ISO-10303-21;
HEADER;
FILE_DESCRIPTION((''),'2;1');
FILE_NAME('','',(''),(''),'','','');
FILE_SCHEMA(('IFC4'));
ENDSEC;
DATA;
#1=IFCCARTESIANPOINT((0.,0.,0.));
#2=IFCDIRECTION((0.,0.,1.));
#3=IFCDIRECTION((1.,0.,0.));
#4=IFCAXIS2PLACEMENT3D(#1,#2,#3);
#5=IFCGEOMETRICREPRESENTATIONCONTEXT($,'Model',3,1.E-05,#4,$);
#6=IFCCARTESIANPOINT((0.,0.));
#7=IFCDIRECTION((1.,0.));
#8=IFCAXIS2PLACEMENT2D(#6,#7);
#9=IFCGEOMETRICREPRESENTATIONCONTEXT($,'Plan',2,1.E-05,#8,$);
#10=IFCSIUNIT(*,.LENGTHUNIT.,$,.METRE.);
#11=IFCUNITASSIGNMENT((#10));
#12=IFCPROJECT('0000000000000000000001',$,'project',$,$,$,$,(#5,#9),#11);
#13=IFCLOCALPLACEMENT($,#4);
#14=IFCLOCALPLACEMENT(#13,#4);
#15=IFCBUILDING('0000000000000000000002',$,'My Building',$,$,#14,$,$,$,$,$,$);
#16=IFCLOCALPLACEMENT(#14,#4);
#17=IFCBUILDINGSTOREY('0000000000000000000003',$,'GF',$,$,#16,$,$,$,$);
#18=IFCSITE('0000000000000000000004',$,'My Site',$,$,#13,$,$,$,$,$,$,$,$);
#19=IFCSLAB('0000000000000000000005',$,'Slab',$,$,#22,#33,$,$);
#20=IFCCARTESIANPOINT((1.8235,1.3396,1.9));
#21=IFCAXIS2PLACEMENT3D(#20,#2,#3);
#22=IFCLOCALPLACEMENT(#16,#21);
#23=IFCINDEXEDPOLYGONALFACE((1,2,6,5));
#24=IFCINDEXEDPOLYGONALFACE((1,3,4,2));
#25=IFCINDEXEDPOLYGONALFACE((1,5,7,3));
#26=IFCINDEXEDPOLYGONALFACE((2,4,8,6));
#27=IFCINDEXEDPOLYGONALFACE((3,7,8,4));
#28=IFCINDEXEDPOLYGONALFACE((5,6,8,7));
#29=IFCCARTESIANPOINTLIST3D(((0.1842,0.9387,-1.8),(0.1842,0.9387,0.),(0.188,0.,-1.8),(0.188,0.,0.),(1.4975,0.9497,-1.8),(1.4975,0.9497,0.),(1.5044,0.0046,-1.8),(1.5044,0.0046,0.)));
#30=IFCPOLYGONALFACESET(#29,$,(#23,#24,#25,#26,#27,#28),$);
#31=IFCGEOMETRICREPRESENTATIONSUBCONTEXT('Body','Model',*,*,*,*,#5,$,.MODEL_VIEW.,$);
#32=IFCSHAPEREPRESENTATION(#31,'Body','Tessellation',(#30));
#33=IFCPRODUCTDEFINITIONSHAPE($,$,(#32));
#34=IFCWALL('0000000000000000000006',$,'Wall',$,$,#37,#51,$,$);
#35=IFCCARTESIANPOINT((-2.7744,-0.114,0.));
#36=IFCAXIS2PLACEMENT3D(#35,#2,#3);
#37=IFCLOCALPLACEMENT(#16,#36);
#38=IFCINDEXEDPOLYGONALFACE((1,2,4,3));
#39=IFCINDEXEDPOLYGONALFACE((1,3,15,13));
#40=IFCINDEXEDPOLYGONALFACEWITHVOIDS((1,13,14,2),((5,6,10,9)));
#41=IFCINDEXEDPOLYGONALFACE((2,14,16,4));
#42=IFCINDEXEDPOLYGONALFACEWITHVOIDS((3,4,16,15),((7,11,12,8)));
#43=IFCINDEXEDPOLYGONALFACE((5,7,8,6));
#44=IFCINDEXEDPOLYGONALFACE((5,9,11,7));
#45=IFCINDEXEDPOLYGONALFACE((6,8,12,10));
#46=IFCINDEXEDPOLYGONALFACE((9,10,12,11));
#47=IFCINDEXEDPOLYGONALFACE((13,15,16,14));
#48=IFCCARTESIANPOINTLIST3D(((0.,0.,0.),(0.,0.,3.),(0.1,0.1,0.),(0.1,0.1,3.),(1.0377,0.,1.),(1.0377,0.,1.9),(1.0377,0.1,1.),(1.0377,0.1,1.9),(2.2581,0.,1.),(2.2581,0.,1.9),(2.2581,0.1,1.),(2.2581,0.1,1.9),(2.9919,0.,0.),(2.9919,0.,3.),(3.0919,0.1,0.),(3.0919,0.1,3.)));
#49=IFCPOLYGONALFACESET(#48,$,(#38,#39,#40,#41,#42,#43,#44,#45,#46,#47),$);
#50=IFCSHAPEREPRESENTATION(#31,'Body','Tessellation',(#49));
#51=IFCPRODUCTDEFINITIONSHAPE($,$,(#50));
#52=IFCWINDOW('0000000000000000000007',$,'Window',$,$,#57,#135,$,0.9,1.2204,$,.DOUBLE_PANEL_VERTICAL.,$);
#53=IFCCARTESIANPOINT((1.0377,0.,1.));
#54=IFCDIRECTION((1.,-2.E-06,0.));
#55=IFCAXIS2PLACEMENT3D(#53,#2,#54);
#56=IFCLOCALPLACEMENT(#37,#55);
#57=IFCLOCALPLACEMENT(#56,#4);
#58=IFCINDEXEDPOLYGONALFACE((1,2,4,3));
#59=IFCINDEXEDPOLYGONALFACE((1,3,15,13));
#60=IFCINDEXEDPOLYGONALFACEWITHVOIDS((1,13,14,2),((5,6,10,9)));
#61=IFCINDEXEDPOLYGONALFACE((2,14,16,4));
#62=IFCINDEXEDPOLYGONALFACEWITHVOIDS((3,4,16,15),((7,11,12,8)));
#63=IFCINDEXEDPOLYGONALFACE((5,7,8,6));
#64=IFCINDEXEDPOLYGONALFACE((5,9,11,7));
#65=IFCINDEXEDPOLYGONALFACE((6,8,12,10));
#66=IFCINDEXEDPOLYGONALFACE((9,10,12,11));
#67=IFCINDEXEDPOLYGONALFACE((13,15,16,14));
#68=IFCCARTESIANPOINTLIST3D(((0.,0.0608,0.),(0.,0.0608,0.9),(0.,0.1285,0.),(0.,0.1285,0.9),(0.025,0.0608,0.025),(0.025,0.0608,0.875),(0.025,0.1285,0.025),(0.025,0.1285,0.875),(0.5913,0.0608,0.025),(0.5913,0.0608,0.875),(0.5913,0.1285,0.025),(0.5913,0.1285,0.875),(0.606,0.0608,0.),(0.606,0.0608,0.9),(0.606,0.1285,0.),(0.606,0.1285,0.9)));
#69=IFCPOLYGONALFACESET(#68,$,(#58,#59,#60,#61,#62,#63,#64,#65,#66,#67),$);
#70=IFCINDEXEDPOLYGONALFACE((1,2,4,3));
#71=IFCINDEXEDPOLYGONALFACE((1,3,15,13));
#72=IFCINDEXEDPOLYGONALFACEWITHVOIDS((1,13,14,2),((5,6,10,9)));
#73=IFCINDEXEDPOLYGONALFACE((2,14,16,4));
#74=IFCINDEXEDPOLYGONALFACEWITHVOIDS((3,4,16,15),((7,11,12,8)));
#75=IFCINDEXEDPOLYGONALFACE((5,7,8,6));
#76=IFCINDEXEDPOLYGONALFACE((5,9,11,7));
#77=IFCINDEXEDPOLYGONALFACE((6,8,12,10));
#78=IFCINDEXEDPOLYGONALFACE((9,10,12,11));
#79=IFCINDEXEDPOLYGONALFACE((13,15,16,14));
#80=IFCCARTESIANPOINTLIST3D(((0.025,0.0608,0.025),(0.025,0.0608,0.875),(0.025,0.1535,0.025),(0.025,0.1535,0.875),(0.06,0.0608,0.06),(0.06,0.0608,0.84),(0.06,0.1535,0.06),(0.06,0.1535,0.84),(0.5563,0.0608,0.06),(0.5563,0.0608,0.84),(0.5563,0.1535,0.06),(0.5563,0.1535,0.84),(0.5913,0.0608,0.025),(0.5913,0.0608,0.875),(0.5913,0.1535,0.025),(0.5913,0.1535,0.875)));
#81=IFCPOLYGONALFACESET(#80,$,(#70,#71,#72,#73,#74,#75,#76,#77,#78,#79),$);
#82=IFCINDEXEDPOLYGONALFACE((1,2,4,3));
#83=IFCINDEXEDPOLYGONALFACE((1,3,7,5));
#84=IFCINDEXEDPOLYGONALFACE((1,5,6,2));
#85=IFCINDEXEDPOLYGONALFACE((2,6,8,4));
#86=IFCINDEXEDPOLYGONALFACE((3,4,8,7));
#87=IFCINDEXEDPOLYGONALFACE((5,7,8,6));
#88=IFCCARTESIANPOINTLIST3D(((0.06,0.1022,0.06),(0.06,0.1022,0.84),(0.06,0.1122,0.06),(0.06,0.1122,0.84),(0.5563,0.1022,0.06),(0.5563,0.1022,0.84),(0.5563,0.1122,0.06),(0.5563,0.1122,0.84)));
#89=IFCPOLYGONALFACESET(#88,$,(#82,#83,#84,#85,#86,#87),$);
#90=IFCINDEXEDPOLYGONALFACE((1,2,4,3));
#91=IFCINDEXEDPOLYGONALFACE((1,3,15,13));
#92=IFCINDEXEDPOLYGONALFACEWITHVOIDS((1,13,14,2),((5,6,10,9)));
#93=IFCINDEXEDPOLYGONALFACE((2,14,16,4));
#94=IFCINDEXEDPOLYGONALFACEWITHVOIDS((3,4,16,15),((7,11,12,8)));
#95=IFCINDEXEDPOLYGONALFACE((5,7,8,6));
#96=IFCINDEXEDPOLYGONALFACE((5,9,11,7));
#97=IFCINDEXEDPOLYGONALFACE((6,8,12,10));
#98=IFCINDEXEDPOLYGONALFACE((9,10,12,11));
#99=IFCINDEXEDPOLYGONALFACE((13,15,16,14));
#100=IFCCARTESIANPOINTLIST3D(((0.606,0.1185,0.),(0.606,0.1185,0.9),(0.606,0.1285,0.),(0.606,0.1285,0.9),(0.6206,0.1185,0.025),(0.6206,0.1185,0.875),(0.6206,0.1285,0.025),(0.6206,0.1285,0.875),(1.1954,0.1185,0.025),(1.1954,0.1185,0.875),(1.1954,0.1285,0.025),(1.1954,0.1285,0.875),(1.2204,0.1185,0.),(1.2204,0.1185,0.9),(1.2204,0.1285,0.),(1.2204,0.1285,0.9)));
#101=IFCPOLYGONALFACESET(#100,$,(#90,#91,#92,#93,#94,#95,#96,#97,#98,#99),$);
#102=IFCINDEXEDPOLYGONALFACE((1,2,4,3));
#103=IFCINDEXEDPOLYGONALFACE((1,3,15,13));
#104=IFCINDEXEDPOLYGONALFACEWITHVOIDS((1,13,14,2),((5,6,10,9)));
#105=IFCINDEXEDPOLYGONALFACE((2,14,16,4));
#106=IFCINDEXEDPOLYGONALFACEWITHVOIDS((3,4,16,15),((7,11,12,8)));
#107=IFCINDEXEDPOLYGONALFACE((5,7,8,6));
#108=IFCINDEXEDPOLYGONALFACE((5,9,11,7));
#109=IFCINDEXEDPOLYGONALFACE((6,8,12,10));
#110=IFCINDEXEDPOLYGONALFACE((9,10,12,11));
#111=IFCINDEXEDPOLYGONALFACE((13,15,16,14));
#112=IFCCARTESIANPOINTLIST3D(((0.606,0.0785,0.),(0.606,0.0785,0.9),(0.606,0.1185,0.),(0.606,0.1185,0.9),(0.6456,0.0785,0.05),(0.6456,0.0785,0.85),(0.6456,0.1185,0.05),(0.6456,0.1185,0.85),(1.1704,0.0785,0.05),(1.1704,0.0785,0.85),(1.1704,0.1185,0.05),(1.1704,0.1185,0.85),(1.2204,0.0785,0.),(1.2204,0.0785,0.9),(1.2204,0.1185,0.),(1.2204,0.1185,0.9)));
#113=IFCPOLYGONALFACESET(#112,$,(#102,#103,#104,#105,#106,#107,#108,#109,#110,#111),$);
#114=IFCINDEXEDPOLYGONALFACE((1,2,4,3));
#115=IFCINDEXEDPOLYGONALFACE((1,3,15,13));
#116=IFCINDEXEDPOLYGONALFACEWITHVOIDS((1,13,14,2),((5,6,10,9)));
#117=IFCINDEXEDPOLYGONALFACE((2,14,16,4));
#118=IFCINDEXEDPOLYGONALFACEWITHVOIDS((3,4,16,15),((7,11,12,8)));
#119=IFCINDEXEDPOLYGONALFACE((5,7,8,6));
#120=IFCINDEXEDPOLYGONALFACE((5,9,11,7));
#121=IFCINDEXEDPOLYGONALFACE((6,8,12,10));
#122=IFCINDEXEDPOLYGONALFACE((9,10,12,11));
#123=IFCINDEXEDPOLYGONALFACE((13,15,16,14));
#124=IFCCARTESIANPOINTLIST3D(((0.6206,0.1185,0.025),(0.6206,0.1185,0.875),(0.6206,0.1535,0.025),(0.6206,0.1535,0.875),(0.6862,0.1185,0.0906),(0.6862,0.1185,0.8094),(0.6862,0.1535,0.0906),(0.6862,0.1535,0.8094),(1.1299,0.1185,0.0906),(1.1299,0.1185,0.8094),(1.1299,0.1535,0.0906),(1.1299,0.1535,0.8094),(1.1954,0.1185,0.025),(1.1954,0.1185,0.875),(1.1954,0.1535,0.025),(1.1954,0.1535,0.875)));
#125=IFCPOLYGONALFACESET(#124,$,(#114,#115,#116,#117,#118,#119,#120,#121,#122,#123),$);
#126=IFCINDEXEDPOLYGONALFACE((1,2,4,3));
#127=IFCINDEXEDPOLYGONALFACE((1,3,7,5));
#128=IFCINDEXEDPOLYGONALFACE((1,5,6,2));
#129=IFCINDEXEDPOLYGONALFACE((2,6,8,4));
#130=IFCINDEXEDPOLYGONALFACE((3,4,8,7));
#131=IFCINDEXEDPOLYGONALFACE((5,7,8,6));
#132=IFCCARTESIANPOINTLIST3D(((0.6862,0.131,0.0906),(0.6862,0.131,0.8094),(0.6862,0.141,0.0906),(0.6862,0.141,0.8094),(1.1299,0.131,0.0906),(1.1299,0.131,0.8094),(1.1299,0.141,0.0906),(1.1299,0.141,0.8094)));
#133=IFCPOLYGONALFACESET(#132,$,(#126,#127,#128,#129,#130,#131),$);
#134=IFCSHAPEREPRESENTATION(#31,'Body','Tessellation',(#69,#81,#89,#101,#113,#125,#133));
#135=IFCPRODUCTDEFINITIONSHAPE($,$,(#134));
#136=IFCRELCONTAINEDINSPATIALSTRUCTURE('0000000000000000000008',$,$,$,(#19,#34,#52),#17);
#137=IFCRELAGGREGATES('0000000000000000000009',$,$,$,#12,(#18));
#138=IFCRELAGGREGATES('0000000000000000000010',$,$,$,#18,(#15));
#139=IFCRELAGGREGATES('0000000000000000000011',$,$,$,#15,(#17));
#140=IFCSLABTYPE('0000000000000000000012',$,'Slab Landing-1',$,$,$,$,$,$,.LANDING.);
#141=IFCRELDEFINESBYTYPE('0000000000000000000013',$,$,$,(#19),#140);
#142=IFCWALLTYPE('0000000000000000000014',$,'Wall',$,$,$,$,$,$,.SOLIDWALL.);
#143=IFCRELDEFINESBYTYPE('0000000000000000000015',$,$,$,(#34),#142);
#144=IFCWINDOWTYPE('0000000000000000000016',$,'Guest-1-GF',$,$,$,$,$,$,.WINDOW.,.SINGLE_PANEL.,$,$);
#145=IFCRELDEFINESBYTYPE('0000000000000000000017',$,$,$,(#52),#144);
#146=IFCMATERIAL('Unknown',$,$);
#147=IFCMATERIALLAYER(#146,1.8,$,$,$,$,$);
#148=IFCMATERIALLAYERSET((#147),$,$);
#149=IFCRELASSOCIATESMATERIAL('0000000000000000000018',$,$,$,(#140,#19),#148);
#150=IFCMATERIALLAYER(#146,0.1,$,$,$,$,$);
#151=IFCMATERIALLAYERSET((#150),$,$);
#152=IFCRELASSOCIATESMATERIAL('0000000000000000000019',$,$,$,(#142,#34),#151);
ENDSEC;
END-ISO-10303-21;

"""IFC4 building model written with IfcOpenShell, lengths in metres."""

from ifc_helpers import new_model, entity, si_unit, frame, origin_with_axes, origin_2d_with_axis, place, context, subcontext, project, spatial, line, indexed_curve, outline, extrude, shape, source, transform, mapped, material, layer, layer_set, layer_usage, type_object, type_shapes, element, fill, save


model = new_model("IFC4")

# Units and contexts
model_context = context("Model", 3, precision=1e-05, world=origin_with_axes())
plan_context = context("Plan", 2, precision=1e-05, world=origin_2d_with_axis())
body_context_1 = subcontext(model_context, "Body", "Model", "MODEL_VIEW")
body_context_2 = subcontext(plan_context, "Body", "Plan", "PLAN_VIEW")
ifc_project = project(units=[si_unit("LENGTHUNIT", "METRE")], contexts=[model_context, plan_context])

# Site, building, storey
site_placement = place(None, origin_with_axes())
site = spatial("IfcSite", under=ifc_project, at=site_placement, Name="My Site")
building_placement = place(site_placement, origin_with_axes())
building = spatial("IfcBuilding", under=site, at=building_placement, Name="My Building")
storey_placement = place(building_placement, origin_with_axes())
storey = spatial("IfcBuildingStorey", under=building, at=storey_placement, Name="GF")

# Shared definitions
ifc_material = material(Name="Unknown")

# Slab
ifc_layer_1 = layer(ifc_material, 1.8)
ifc_layer_set_1 = layer_set([ifc_layer_1])
ifc_layer_usage_1 = layer_usage(ifc_layer_set_1, "AXIS3", "POSITIVE", -1.8)
slab_type_1 = type_object("IfcSlabType", Name="Slab Landing-1", PredefinedType="LANDING", material=ifc_layer_set_1)
slab_1_placement = place(storey_placement, frame((1.8235, 1.3396, 1.9), z_axis=(0.0, 0.0, 1.0), x_axis=(1.0, 0.0, 0.0)))
element("IfcSlab", 1, at=slab_1_placement, inside=storey, type_object=slab_type_1, material=ifc_layer_usage_1, Name="Slab", context=body_context_1, shape_type="SweptSolid", body=[
    extrude(outline(indexed_curve([(0.1842, 0.9387), (1.4975, 0.9497), (1.5044, 0.0046), (0.188, 0.0), (0.1842, 0.9387)])), frame((0.0, 0.0, -1.8), z_axis=(0.0, 0.0, 1.0), x_axis=(1.0, 0.0, 0.0)), (0.0, 0.0, 1.0), 1.8),
])

# Shared definitions
ifc_layer_2 = layer(ifc_material, 0.1)
ifc_layer_set_2 = layer_set([ifc_layer_2])
wall_type = type_object("IfcWallType", Name="Wall", PredefinedType="SOLIDWALL", material=ifc_layer_set_2)

# Wall, opening, window
ifc_layer_usage_2 = layer_usage(ifc_layer_set_2, "AXIS2", "POSITIVE", 0.0)
wall_1_placement = place(storey_placement, frame((-2.7744, -0.114, 0.0), z_axis=(0.0, 0.0, 1.0), x_axis=(1.0, 0.0, 0.0)))
wall_1 = element("IfcWall", 2, at=wall_1_placement, inside=storey, type_object=wall_type, material=ifc_layer_usage_2, Name="Wall", context=body_context_1, shape_type="SweptSolid", body=[
    extrude(outline(indexed_curve([(0.0, 0.0), (0.1, 0.1), (3.0919, 0.1), (2.9919, 0.0)], segments=[line(1, 2, 3, 4, 1)])), origin_with_axes(), (0.0, 0.0, 1.0), 3.0),
])
shared_shape_1 = source(origin_with_axes(), body_context_1, "Body", "SweptSolid", [
    extrude(outline(indexed_curve([(0.0, 0.0), (1.2204, 0.0), (1.2204, 0.9), (0.0, 0.9)], segments=[line(1, 2, 3, 4, 1)])), frame((0.0, -0.6, 0.0), z_axis=(0.0, -1.0, 0.0), x_axis=(1.0, 0.0, 0.0)), (0.0, 0.0, -1.0), 1.2),
])
opening_1_placement = place(wall_1_placement, frame((1.0377, 0.0, 1.0), z_axis=(0.0, 0.0, 1.0), x_axis=(1.0, -0.000002, 0.0)))
opening_1 = element("IfcOpeningElement", 3, at=opening_1_placement, cuts=wall_1, PredefinedType="OPENING", context=body_context_1, shape_type="MappedRepresentation", body=[
    mapped(shared_shape_1, transform((0.0, 0.0, 0.0), x_axis=(1.0, 0.0, 0.0), y_axis=(0.0, 1.0, 0.0), z_axis=(0.0, 0.0, 1.0), scale=1.0)),
])
window_type_1 = type_object("IfcWindowType", Name="Guest-1-GF", PartitioningType="SINGLE_PANEL", PredefinedType="WINDOW")
shared_shape_2 = source(origin_with_axes(), body_context_1, "Body", "SweptSolid", [
    extrude(outline(indexed_curve([(0.0, 0.0), (0.606, 0.0), (0.606, 0.9), (0.0, 0.9)], segments=[line(1, 2, 3, 4, 1)]), holes=[indexed_curve([(0.025, 0.025), (0.5913, 0.025), (0.5913, 0.875), (0.025, 0.875)], segments=[line(1, 2, 3, 4, 1)])]), frame((0.0, 0.0608, 0.0), z_axis=(0.0, -1.0, 0.0), x_axis=(1.0, 0.0, 0.0)), (0.0, 0.0, -1.0), 0.0677),
    extrude(outline(indexed_curve([(0.0, 0.0), (0.606, 0.0), (0.606, 0.9), (0.0, 0.9)], segments=[line(1, 2, 3, 4, 1)]), holes=[indexed_curve([(0.05, 0.05), (0.5663, 0.05), (0.5663, 0.85), (0.05, 0.85)], segments=[line(1, 2, 3, 4, 1)])]), frame((0.0, 0.0785, 0.0), z_axis=(0.0, -1.0, 0.0), x_axis=(1.0, 0.0, 0.0)), (0.0, 0.0, -1.0), -0.0177),
    extrude(outline(indexed_curve([(0.0, 0.0), (0.5663, 0.0), (0.5663, 0.85), (0.0, 0.85)], segments=[line(1, 2, 3, 4, 1)]), holes=[indexed_curve([(0.035, 0.035), (0.5313, 0.035), (0.5313, 0.815), (0.035, 0.815)], segments=[line(1, 2, 3, 4, 1)])]), frame((0.025, 0.0608, 0.025), z_axis=(0.0, -1.0, 0.0), x_axis=(1.0, 0.0, 0.0)), (0.0, 0.0, -1.0), 0.0927),
    extrude(outline(indexed_curve([(0.035, 0.035), (0.5313, 0.035), (0.5313, 0.815), (0.035, 0.815)], segments=[line(1, 2, 3, 4, 1)])), frame((0.025, 0.1022, 0.025), z_axis=(0.0, -1.0, 0.0), x_axis=(1.0, 0.0, 0.0)), (0.0, 0.0, -1.0), 0.01),
    extrude(outline(indexed_curve([(0.0, 0.0), (0.6144, 0.0), (0.6144, 0.9), (0.0, 0.9)], segments=[line(1, 2, 3, 4, 1)]), holes=[indexed_curve([(0.0147, 0.025), (0.5894, 0.025), (0.5894, 0.875), (0.0147, 0.875)], segments=[line(1, 2, 3, 4, 1)])]), frame((0.606, 0.1185, 0.0), z_axis=(0.0, -1.0, 0.0), x_axis=(1.0, 0.0, 0.0)), (0.0, 0.0, -1.0), 0.01),
    extrude(outline(indexed_curve([(0.0, 0.0), (0.6144, 0.0), (0.6144, 0.9), (0.0, 0.9)], segments=[line(1, 2, 3, 4, 1)]), holes=[indexed_curve([(0.0397, 0.05), (0.5644, 0.05), (0.5644, 0.85), (0.0397, 0.85)], segments=[line(1, 2, 3, 4, 1)])]), frame((0.606, 0.0785, 0.0), z_axis=(0.0, -1.0, 0.0), x_axis=(1.0, 0.0, 0.0)), (0.0, 0.0, -1.0), 0.04),
    extrude(outline(indexed_curve([(0.0, 0.0), (0.5748, 0.0), (0.5748, 0.85), (0.0, 0.85)], segments=[line(1, 2, 3, 4, 1)]), holes=[indexed_curve([(0.0656, 0.0656), (0.5092, 0.0656), (0.5092, 0.7844), (0.0656, 0.7844)], segments=[line(1, 2, 3, 4, 1)])]), frame((0.6206, 0.1185, 0.025), z_axis=(0.0, -1.0, 0.0), x_axis=(1.0, 0.0, 0.0)), (0.0, 0.0, -1.0), 0.035),
    extrude(outline(indexed_curve([(0.0656, 0.0656), (0.5092, 0.0656), (0.5092, 0.7844), (0.0656, 0.7844)], segments=[line(1, 2, 3, 4, 1)])), frame((0.6206, 0.131, 0.025), z_axis=(0.0, -1.0, 0.0), x_axis=(1.0, 0.0, 0.0)), (0.0, 0.0, -1.0), 0.01),
])
shared_shape_3 = source(origin_with_axes(), body_context_2, "Body", "Curve2D", [
    entity("IfcIndexedPolyCurve", entity("IfcCartesianPointList2D", [[0.05, 0.0785], [0.5663, 0.0785]])),
    entity("IfcIndexedPolyCurve", entity("IfcCartesianPointList2D", [[0.0, 0.1285], [0.025, 0.1285], [0.025, 0.0608], [0.05, 0.0608], [0.05, 0.0785], [0.0, 0.0785]]), [entity("IfcLineIndex", [1, 2, 3, 4, 5, 6, 1])]),
    entity("IfcIndexedPolyCurve", entity("IfcCartesianPointList2D", [[0.606, 0.1285], [0.5913, 0.1285], [0.5913, 0.0608], [0.5663, 0.0608], [0.5663, 0.0785], [0.606, 0.0785]])),
    entity("IfcIndexedPolyCurve", entity("IfcCartesianPointList2D", [[0.025, 0.0608], [0.06, 0.0608], [0.06, 0.1535], [0.025, 0.1535]]), [entity("IfcLineIndex", [1, 2, 3, 4, 1])]),
    entity("IfcIndexedPolyCurve", entity("IfcCartesianPointList2D", [[0.5913, 0.0608], [0.5563, 0.0608], [0.5563, 0.1535], [0.5913, 0.1535]]), [entity("IfcLineIndex", [1, 2, 3, 4, 1])]),
    entity("IfcIndexedPolyCurve", entity("IfcCartesianPointList2D", [[0.06, 0.0608], [0.5563, 0.0608]])),
    entity("IfcIndexedPolyCurve", entity("IfcCartesianPointList2D", [[0.06, 0.1535], [0.5563, 0.1535]])),
    entity("IfcIndexedPolyCurve", entity("IfcCartesianPointList2D", [[0.06, 0.1072], [0.5563, 0.1072]])),
    entity("IfcIndexedPolyCurve", entity("IfcCartesianPointList2D", [[0.6456, 0.0785], [1.1704, 0.0785]])),
    entity("IfcIndexedPolyCurve", entity("IfcCartesianPointList2D", [[0.606, 0.1285], [0.6206, 0.1285], [0.6206, 0.1185], [0.6456, 0.1185], [0.6456, 0.0785], [0.606, 0.0785]])),
    entity("IfcIndexedPolyCurve", entity("IfcCartesianPointList2D", [[1.2204, 0.1285], [1.1954, 0.1285], [1.1954, 0.1185], [1.1704, 0.1185], [1.1704, 0.0785], [1.2204, 0.0785]]), [entity("IfcLineIndex", [1, 2, 3, 4, 5, 6, 1])]),
    entity("IfcIndexedPolyCurve", entity("IfcCartesianPointList2D", [[0.6206, 0.1185], [0.6862, 0.1185], [0.6862, 0.1535], [0.6206, 0.1535]]), [entity("IfcLineIndex", [1, 2, 3, 4, 1])]),
    entity("IfcIndexedPolyCurve", entity("IfcCartesianPointList2D", [[1.1954, 0.1185], [1.1299, 0.1185], [1.1299, 0.1535], [1.1954, 0.1535]]), [entity("IfcLineIndex", [1, 2, 3, 4, 1])]),
    entity("IfcIndexedPolyCurve", entity("IfcCartesianPointList2D", [[0.6862, 0.1185], [1.1299, 0.1185]])),
    entity("IfcIndexedPolyCurve", entity("IfcCartesianPointList2D", [[0.6862, 0.1535], [1.1299, 0.1535]])),
    entity("IfcIndexedPolyCurve", entity("IfcCartesianPointList2D", [[0.6862, 0.136], [1.1299, 0.136]])),
])
type_shapes(window_type_1, [shared_shape_2, shared_shape_3])
window_1_placement = place(opening_1_placement, frame((0.0, 0.0, 0.0), z_axis=(0.0, 0.0, 1.0), x_axis=(1.0, 0.0, 0.0)))
window_1 = element("IfcWindow", 4, at=window_1_placement, inside=storey, type_object=window_type_1, Name="Window", OverallHeight=0.9, OverallWidth=1.2204, PartitioningType="DOUBLE_PANEL_VERTICAL", shapes=[
    shape(body_context_1, "Body", "MappedRepresentation", [mapped(shared_shape_2, transform((0.0, 0.0, 0.0), x_axis=(1.0, 0.0, 0.0), y_axis=(0.0, 1.0, 0.0), z_axis=(0.0, 0.0, 1.0), scale=1.0))]),
    shape(body_context_2, "Body", "MappedRepresentation", [mapped(shared_shape_3, transform((0.0, 0.0, 0.0), x_axis=(1.0, 0.0, 0.0), y_axis=(0.0, 1.0, 0.0), z_axis=(0.0, 0.0, 1.0), scale=1.0))]),
])
fill(opening_1, window_1)

save(model, "model.ifc")
